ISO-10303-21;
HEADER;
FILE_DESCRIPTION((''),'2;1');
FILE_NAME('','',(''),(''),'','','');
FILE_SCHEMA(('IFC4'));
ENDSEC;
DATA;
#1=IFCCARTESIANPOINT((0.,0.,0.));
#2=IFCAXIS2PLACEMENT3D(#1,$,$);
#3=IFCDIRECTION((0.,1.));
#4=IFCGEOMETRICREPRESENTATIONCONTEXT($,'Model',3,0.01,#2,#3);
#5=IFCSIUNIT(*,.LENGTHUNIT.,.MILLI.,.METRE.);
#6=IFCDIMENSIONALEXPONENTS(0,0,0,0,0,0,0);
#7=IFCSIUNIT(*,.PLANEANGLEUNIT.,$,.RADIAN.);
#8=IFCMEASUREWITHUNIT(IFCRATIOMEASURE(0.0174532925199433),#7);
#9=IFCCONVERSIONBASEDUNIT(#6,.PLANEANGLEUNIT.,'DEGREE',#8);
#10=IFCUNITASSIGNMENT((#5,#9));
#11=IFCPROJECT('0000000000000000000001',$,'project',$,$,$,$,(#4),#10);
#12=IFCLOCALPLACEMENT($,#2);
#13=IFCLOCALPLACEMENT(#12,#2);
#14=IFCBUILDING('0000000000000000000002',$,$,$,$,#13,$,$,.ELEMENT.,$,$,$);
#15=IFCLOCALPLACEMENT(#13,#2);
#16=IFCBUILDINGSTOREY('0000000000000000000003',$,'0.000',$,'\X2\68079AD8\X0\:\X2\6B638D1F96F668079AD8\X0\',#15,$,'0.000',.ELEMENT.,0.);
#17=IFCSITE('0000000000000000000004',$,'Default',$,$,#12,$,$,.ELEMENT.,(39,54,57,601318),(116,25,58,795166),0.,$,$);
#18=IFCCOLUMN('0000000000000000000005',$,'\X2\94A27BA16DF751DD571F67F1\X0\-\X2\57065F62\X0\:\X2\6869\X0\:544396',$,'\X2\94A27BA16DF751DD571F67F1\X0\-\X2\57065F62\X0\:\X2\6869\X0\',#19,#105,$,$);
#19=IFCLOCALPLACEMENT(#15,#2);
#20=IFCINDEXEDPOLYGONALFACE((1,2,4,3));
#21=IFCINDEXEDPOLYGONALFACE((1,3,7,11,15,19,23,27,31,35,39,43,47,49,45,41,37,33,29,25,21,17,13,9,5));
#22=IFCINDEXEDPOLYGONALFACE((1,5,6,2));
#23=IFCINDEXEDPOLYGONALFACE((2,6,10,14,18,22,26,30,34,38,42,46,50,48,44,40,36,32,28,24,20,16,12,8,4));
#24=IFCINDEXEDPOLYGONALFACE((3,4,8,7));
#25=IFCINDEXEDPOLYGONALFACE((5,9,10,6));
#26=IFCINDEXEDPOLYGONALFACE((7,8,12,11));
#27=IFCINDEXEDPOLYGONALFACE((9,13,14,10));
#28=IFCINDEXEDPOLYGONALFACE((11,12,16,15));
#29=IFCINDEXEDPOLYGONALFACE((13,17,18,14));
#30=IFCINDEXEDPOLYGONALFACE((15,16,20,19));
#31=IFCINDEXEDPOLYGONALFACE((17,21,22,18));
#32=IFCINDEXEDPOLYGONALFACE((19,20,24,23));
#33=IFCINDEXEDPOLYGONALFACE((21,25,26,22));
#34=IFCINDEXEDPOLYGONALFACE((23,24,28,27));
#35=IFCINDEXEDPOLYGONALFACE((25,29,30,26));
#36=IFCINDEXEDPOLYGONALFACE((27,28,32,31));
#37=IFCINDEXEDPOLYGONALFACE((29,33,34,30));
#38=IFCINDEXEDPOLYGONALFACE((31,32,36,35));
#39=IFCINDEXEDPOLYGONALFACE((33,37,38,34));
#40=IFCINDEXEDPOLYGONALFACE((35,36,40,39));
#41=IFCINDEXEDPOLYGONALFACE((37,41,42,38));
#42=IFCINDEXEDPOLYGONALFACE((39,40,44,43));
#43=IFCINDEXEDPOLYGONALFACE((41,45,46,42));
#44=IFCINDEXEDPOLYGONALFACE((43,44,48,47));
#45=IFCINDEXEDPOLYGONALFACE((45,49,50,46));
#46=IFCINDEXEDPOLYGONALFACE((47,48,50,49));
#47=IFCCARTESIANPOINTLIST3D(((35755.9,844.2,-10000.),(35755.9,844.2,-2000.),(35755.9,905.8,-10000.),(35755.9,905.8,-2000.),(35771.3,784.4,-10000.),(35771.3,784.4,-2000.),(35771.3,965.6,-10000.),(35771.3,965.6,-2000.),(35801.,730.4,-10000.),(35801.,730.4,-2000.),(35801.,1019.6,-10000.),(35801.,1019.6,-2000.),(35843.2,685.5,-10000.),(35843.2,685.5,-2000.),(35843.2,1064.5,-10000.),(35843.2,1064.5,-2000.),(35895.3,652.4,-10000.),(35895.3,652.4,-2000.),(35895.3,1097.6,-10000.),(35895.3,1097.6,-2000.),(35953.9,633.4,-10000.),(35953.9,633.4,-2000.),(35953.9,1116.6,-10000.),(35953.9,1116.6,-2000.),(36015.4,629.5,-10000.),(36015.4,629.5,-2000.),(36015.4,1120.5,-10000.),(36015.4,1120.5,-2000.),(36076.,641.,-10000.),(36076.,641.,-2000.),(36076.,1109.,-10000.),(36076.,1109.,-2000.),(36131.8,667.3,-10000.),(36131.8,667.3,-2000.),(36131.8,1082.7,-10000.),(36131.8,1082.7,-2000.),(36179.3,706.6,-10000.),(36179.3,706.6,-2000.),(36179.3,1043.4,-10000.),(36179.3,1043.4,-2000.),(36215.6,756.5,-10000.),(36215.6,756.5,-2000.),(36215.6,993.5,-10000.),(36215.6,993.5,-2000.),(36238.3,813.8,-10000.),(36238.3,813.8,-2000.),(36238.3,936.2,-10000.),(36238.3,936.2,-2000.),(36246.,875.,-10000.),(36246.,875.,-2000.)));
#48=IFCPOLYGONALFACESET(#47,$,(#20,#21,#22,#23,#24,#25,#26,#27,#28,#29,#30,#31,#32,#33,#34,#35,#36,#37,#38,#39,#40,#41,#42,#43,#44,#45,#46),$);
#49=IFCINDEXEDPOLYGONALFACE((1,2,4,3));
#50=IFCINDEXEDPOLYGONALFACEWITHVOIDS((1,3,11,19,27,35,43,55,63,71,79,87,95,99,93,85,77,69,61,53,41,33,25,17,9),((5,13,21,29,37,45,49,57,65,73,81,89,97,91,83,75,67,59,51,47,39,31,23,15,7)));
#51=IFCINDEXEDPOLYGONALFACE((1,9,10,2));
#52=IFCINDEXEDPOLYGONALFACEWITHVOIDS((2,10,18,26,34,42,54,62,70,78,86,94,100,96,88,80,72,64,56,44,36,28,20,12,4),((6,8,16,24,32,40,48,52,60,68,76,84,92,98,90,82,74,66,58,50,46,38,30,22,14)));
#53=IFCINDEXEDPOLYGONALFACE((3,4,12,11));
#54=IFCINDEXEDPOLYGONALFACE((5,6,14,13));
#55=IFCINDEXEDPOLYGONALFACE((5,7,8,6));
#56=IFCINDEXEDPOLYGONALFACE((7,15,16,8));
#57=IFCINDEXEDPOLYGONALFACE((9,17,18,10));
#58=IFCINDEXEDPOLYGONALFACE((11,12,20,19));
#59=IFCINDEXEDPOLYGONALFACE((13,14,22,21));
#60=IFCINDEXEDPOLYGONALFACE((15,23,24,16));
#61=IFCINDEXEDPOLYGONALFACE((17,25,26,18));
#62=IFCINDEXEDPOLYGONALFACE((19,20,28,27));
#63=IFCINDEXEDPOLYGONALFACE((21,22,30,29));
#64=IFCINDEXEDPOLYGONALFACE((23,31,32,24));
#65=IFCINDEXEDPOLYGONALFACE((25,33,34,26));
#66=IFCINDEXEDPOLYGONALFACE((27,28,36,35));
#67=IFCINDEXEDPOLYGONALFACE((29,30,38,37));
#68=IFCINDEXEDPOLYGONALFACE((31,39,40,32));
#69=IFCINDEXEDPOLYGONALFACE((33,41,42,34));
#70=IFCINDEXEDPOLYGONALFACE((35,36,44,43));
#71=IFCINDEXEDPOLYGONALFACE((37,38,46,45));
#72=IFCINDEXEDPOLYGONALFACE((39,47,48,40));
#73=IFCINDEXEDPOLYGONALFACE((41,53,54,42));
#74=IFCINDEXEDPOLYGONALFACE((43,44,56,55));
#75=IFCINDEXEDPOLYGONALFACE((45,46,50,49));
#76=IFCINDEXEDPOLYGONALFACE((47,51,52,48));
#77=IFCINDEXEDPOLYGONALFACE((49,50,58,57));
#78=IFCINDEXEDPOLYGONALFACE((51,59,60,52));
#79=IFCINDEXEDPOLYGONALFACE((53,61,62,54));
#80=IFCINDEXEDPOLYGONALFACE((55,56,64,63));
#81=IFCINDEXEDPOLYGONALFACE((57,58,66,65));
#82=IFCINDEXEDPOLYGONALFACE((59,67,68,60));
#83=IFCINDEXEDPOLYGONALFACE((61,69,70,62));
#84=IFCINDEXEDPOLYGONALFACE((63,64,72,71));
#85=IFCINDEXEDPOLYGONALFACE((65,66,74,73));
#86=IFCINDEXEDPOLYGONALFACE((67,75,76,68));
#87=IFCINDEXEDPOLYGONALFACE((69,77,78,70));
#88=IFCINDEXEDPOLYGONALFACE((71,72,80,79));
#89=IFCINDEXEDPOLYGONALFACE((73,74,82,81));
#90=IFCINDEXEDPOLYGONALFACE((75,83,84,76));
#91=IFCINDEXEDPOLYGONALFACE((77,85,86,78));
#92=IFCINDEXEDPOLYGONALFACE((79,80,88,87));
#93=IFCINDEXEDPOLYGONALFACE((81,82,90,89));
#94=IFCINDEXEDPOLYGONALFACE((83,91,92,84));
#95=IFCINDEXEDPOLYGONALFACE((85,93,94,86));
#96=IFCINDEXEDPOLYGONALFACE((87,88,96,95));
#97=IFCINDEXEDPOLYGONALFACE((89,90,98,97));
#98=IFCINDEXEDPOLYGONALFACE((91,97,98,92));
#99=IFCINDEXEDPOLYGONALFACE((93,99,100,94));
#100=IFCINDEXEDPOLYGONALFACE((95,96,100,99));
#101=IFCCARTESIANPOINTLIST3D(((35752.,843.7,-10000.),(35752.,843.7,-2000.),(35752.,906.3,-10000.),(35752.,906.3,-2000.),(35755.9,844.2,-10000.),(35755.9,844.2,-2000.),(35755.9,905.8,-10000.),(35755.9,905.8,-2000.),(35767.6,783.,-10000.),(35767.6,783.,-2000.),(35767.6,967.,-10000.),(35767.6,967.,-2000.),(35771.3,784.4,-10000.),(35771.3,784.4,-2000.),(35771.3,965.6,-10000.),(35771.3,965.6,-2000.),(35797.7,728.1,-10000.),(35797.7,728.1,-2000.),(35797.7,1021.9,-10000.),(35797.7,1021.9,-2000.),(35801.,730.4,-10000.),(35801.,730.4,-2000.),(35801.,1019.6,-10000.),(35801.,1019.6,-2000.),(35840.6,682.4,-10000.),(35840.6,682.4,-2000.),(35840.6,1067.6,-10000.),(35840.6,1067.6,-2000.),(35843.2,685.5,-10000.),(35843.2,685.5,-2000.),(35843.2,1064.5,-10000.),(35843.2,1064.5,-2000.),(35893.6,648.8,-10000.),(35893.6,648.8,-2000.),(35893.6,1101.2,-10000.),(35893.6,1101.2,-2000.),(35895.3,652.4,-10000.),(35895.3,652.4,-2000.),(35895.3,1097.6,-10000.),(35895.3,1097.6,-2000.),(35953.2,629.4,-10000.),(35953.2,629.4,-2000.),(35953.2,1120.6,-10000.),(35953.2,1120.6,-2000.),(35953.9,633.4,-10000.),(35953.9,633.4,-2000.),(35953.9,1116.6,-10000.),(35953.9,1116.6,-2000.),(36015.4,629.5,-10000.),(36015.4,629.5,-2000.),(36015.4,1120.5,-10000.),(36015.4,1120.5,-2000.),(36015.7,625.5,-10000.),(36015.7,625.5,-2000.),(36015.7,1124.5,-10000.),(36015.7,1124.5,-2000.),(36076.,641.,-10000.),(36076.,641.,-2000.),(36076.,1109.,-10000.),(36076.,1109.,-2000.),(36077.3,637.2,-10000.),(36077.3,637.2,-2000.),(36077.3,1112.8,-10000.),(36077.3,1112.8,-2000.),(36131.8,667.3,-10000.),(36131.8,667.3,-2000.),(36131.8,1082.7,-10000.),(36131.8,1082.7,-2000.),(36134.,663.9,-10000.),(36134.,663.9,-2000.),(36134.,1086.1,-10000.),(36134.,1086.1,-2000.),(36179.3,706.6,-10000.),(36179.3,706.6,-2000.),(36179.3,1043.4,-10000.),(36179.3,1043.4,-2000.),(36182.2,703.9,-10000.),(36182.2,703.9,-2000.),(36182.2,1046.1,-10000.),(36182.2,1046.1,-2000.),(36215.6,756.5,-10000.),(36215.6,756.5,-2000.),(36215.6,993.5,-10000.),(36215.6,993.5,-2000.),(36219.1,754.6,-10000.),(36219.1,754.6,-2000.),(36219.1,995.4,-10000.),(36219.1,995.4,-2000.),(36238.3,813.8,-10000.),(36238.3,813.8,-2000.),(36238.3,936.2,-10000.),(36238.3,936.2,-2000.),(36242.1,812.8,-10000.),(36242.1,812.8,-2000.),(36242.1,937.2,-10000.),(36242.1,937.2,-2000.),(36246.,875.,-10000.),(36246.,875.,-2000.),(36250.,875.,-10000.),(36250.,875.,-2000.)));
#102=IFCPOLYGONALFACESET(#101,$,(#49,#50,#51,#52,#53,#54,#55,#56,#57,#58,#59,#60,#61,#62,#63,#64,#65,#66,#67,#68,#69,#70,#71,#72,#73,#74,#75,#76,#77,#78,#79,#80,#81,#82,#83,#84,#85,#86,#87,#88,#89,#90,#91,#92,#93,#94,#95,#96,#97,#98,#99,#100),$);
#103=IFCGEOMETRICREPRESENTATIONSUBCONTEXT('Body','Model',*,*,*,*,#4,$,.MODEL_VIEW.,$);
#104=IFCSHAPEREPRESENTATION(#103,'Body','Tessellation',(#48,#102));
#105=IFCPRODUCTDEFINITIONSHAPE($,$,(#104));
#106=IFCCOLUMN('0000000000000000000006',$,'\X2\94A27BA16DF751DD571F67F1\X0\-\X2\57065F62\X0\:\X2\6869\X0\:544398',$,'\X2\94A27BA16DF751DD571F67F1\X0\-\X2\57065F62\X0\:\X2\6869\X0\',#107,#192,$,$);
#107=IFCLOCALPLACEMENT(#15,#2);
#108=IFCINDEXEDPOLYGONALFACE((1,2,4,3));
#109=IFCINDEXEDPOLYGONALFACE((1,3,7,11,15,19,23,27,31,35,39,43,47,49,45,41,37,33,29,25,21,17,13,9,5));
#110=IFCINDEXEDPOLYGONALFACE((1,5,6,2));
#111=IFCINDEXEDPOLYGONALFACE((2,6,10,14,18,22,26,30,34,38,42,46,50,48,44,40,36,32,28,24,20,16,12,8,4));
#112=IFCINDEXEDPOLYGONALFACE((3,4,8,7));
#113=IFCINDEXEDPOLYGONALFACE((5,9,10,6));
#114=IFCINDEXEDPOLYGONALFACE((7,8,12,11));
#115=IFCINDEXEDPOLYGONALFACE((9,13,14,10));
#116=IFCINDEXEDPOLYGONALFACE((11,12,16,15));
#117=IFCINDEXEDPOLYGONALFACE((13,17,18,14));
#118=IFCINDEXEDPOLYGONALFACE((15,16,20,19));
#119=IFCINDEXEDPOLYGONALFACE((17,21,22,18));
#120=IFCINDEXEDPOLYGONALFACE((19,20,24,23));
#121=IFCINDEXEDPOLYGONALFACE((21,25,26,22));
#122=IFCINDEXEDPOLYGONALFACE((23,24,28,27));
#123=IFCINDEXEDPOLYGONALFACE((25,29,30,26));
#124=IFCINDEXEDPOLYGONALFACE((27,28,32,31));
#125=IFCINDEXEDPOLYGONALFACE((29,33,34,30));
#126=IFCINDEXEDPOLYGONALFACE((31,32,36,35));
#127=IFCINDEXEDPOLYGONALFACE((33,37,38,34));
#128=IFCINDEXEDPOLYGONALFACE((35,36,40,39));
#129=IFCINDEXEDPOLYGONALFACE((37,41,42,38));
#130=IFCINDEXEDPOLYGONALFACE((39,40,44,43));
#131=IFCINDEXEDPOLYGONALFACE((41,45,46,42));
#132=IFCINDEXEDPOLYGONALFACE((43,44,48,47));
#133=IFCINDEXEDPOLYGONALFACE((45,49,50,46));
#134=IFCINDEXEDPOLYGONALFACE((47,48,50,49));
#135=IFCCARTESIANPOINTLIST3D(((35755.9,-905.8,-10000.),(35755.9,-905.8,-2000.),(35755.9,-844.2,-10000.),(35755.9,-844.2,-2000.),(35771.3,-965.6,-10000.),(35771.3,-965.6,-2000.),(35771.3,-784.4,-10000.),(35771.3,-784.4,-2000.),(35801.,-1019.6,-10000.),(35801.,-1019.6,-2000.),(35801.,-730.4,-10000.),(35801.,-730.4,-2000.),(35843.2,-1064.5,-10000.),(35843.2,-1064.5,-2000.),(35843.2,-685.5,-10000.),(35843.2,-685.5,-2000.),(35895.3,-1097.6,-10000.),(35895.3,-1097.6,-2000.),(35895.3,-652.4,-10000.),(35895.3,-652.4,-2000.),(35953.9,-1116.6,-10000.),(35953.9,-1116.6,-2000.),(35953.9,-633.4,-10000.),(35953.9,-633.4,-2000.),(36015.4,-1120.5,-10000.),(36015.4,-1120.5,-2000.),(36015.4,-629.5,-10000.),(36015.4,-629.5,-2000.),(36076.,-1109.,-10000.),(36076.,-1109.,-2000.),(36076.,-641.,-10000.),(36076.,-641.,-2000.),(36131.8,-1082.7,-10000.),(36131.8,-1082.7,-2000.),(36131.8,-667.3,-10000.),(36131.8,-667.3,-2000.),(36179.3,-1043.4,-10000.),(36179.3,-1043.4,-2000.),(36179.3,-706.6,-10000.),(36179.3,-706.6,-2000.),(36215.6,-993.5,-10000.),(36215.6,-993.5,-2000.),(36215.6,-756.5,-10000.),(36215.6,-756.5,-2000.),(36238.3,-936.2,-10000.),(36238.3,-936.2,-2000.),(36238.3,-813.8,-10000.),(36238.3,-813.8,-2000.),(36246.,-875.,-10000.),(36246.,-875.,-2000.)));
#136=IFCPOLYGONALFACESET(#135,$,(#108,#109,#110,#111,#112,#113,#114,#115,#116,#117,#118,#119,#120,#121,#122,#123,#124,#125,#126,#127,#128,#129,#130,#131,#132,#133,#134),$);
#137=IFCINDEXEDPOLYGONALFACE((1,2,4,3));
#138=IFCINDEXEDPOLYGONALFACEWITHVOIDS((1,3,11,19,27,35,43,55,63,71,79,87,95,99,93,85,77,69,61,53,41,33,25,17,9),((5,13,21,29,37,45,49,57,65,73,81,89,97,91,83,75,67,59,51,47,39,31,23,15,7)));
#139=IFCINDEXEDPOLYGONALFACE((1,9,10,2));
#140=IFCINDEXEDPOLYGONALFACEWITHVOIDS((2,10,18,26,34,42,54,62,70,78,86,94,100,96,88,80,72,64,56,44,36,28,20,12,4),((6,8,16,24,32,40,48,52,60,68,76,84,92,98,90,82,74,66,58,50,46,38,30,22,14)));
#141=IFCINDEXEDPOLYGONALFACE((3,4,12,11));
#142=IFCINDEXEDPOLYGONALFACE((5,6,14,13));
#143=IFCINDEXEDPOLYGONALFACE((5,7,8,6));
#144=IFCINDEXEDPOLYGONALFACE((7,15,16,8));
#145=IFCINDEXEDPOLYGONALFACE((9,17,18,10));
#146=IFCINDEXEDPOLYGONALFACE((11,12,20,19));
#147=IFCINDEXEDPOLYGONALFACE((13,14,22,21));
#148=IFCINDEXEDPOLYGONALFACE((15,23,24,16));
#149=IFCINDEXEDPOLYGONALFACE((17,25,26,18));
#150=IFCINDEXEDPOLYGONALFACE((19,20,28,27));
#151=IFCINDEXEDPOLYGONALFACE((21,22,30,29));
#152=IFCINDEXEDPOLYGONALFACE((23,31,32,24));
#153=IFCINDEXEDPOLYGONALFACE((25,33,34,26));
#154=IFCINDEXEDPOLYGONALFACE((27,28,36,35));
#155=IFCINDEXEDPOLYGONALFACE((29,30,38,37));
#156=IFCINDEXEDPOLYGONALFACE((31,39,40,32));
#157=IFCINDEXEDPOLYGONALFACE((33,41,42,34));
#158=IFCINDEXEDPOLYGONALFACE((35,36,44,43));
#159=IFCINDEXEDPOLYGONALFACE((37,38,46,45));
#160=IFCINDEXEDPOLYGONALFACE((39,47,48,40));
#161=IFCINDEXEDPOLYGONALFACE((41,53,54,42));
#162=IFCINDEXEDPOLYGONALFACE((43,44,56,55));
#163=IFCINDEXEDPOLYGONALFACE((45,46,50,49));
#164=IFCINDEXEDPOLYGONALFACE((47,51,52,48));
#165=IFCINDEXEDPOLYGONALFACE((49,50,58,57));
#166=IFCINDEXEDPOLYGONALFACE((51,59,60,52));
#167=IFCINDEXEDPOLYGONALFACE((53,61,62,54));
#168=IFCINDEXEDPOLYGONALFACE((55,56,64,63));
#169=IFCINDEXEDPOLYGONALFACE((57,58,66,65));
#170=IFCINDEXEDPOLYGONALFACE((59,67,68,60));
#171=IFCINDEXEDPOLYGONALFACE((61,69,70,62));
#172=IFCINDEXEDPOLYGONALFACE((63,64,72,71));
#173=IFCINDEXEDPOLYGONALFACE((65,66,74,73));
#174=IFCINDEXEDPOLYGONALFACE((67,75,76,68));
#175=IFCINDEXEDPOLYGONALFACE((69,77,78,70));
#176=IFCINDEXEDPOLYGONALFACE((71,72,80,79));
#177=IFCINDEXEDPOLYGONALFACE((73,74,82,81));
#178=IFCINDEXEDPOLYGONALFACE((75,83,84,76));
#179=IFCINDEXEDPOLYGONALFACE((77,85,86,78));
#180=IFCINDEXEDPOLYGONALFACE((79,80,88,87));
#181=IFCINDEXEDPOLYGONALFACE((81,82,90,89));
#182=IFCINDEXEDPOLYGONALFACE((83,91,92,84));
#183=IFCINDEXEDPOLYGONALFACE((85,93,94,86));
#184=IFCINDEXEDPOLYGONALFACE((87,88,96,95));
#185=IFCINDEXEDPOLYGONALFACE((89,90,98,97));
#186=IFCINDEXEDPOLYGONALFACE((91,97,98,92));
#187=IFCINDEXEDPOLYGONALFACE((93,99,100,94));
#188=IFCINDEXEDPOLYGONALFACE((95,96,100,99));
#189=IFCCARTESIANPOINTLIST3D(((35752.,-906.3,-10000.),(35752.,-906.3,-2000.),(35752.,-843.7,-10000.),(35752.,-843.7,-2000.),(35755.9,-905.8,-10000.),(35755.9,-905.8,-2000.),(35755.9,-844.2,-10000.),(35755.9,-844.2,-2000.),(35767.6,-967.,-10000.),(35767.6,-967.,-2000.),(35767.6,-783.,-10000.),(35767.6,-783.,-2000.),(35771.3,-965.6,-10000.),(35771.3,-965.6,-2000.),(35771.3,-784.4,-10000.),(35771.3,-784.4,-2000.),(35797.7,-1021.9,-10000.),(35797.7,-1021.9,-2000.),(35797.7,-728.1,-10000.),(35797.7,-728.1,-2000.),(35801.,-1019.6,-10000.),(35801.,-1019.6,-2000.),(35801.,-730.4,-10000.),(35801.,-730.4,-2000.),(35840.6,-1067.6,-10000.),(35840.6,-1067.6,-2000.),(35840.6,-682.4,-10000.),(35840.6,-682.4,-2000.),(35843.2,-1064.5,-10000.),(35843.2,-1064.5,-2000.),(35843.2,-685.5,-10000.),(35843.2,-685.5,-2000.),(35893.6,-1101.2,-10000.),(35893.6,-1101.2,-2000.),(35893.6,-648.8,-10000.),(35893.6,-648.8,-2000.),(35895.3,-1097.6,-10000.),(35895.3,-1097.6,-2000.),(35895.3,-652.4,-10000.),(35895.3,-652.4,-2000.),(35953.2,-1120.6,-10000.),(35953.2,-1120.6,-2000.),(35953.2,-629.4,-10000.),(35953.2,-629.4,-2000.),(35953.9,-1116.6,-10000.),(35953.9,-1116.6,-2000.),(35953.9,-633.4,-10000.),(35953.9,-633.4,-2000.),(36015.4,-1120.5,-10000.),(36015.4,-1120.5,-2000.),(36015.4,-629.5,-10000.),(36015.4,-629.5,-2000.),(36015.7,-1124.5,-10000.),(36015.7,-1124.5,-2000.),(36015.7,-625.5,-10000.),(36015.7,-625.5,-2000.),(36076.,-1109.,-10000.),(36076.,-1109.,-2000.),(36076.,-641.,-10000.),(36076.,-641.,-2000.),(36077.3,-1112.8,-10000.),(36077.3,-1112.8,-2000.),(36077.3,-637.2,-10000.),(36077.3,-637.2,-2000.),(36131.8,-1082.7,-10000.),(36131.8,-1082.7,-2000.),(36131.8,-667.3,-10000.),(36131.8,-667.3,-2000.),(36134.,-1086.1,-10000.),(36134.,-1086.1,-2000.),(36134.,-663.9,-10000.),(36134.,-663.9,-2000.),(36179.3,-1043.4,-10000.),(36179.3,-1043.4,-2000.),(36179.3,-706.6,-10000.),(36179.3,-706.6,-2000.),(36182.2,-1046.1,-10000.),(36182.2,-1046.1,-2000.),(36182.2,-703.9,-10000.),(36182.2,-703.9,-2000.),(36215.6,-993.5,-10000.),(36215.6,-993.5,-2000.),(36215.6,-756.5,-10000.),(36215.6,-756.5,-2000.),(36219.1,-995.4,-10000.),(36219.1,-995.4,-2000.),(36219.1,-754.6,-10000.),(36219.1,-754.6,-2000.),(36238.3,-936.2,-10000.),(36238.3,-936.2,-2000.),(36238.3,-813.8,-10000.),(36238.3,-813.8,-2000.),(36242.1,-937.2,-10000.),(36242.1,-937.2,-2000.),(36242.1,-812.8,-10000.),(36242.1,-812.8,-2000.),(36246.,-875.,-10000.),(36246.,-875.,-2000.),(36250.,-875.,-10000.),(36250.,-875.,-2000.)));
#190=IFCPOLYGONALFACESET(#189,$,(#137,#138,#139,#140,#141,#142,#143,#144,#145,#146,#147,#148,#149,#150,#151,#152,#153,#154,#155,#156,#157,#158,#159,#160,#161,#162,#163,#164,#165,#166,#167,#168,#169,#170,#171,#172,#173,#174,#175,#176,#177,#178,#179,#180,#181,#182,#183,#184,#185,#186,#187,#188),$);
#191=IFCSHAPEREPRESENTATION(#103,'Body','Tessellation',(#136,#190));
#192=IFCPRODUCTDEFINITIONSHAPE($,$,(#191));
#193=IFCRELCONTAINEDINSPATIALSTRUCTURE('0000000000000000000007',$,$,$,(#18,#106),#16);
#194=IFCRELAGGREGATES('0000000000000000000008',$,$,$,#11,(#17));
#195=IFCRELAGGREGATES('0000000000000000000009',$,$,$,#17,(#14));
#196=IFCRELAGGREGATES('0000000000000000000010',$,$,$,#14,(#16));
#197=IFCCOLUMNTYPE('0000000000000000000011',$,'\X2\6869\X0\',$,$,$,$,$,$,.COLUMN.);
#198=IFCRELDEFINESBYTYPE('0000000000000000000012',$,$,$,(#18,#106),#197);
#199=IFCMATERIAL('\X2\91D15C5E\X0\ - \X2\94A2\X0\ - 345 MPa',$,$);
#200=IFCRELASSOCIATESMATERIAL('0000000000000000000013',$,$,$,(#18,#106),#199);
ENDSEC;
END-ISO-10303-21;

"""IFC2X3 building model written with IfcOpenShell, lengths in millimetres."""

from ifc_helpers import new_model, entity, si_unit, converted_unit, direction, frame, frame_2d, origin, place, context, subcontext, project, spatial, circle, hollow_circle, extrude, source, transform, mapped, material, type_object, type_shapes, element, save


model = new_model("IFC2X3")

# Units and contexts
model_context = context("Model", 3, precision=0.01, world=origin(), true_north=direction((0.0, 1.0)))
body_context = subcontext(model_context, "Body", "Model", "MODEL_VIEW")
ifc_project = project(units=[si_unit("LENGTHUNIT", "METRE", prefix="MILLI"), converted_unit("PLANEANGLEUNIT", "DEGREE", entity("IfcRatioMeasure", 0.0174532925199433), si_unit("PLANEANGLEUNIT", "RADIAN"), dimensions=[0, 0, 0, 0, 0, 0, 0])], contexts=[model_context])

# Site, building, storey
site_placement = place(None, origin())
site = spatial("IfcSite", under=ifc_project, at=site_placement, Name="Default", CompositionType="ELEMENT", RefLatitude=(39, 54, 57, 601318), RefLongitude=(116, 25, 58, 795166), RefElevation=0.0)
building_placement = place(site_placement, origin())
building = spatial("IfcBuilding", under=site, at=building_placement, CompositionType="ELEMENT")
storey_placement = place(building_placement, origin())
storey = spatial("IfcBuildingStorey", under=building, at=storey_placement, Name="0.000", ObjectType="标高:正负零标高", LongName="0.000", CompositionType="ELEMENT", Elevation=0.0)

# Columns
ifc_material_1 = material(Name="金属 - 钢 - 345 MPa")
column_type = type_object("IfcColumnType", Name="桩", PredefinedType="COLUMN")
shared_shape = source(origin(), body_context, "Body", "SweptSolid", [
    extrude(circle(Radius=246.0, at=frame_2d((0.0, 0.0), x_axis=(1.0, 0.0))), frame((0.0, 0.0, -10000.0)), (0.0, 0.0, 1.0), 8000.0),
    extrude(hollow_circle(Radius=250.0, WallThickness=4.0, at=frame_2d((0.0, 0.0), x_axis=(1.0, 0.0))), frame((0.0, 0.0, -10000.0)), (0.0, 0.0, 1.0), 8000.0),
])
type_shapes(column_type, [shared_shape])
for number, where, name in (
    (1, (36000.0, 875.0, 0.0), "钢管混凝土柱-圆形:桩:544396"),
    (2, (36000.0, -875.0, 0.0), "钢管混凝土柱-圆形:桩:544398"),
):
    element("IfcColumn", number, at=place(storey_placement, frame(where)), inside=storey, type_object=column_type, material=ifc_material_1, Name=name, ObjectType="钢管混凝土柱-圆形:桩", context=body_context, shape_type="MappedRepresentation", body=[
        mapped(shared_shape, transform((0.0, 0.0, 0.0), scale=1.0)),
    ])

save(model, "model.ifc")
